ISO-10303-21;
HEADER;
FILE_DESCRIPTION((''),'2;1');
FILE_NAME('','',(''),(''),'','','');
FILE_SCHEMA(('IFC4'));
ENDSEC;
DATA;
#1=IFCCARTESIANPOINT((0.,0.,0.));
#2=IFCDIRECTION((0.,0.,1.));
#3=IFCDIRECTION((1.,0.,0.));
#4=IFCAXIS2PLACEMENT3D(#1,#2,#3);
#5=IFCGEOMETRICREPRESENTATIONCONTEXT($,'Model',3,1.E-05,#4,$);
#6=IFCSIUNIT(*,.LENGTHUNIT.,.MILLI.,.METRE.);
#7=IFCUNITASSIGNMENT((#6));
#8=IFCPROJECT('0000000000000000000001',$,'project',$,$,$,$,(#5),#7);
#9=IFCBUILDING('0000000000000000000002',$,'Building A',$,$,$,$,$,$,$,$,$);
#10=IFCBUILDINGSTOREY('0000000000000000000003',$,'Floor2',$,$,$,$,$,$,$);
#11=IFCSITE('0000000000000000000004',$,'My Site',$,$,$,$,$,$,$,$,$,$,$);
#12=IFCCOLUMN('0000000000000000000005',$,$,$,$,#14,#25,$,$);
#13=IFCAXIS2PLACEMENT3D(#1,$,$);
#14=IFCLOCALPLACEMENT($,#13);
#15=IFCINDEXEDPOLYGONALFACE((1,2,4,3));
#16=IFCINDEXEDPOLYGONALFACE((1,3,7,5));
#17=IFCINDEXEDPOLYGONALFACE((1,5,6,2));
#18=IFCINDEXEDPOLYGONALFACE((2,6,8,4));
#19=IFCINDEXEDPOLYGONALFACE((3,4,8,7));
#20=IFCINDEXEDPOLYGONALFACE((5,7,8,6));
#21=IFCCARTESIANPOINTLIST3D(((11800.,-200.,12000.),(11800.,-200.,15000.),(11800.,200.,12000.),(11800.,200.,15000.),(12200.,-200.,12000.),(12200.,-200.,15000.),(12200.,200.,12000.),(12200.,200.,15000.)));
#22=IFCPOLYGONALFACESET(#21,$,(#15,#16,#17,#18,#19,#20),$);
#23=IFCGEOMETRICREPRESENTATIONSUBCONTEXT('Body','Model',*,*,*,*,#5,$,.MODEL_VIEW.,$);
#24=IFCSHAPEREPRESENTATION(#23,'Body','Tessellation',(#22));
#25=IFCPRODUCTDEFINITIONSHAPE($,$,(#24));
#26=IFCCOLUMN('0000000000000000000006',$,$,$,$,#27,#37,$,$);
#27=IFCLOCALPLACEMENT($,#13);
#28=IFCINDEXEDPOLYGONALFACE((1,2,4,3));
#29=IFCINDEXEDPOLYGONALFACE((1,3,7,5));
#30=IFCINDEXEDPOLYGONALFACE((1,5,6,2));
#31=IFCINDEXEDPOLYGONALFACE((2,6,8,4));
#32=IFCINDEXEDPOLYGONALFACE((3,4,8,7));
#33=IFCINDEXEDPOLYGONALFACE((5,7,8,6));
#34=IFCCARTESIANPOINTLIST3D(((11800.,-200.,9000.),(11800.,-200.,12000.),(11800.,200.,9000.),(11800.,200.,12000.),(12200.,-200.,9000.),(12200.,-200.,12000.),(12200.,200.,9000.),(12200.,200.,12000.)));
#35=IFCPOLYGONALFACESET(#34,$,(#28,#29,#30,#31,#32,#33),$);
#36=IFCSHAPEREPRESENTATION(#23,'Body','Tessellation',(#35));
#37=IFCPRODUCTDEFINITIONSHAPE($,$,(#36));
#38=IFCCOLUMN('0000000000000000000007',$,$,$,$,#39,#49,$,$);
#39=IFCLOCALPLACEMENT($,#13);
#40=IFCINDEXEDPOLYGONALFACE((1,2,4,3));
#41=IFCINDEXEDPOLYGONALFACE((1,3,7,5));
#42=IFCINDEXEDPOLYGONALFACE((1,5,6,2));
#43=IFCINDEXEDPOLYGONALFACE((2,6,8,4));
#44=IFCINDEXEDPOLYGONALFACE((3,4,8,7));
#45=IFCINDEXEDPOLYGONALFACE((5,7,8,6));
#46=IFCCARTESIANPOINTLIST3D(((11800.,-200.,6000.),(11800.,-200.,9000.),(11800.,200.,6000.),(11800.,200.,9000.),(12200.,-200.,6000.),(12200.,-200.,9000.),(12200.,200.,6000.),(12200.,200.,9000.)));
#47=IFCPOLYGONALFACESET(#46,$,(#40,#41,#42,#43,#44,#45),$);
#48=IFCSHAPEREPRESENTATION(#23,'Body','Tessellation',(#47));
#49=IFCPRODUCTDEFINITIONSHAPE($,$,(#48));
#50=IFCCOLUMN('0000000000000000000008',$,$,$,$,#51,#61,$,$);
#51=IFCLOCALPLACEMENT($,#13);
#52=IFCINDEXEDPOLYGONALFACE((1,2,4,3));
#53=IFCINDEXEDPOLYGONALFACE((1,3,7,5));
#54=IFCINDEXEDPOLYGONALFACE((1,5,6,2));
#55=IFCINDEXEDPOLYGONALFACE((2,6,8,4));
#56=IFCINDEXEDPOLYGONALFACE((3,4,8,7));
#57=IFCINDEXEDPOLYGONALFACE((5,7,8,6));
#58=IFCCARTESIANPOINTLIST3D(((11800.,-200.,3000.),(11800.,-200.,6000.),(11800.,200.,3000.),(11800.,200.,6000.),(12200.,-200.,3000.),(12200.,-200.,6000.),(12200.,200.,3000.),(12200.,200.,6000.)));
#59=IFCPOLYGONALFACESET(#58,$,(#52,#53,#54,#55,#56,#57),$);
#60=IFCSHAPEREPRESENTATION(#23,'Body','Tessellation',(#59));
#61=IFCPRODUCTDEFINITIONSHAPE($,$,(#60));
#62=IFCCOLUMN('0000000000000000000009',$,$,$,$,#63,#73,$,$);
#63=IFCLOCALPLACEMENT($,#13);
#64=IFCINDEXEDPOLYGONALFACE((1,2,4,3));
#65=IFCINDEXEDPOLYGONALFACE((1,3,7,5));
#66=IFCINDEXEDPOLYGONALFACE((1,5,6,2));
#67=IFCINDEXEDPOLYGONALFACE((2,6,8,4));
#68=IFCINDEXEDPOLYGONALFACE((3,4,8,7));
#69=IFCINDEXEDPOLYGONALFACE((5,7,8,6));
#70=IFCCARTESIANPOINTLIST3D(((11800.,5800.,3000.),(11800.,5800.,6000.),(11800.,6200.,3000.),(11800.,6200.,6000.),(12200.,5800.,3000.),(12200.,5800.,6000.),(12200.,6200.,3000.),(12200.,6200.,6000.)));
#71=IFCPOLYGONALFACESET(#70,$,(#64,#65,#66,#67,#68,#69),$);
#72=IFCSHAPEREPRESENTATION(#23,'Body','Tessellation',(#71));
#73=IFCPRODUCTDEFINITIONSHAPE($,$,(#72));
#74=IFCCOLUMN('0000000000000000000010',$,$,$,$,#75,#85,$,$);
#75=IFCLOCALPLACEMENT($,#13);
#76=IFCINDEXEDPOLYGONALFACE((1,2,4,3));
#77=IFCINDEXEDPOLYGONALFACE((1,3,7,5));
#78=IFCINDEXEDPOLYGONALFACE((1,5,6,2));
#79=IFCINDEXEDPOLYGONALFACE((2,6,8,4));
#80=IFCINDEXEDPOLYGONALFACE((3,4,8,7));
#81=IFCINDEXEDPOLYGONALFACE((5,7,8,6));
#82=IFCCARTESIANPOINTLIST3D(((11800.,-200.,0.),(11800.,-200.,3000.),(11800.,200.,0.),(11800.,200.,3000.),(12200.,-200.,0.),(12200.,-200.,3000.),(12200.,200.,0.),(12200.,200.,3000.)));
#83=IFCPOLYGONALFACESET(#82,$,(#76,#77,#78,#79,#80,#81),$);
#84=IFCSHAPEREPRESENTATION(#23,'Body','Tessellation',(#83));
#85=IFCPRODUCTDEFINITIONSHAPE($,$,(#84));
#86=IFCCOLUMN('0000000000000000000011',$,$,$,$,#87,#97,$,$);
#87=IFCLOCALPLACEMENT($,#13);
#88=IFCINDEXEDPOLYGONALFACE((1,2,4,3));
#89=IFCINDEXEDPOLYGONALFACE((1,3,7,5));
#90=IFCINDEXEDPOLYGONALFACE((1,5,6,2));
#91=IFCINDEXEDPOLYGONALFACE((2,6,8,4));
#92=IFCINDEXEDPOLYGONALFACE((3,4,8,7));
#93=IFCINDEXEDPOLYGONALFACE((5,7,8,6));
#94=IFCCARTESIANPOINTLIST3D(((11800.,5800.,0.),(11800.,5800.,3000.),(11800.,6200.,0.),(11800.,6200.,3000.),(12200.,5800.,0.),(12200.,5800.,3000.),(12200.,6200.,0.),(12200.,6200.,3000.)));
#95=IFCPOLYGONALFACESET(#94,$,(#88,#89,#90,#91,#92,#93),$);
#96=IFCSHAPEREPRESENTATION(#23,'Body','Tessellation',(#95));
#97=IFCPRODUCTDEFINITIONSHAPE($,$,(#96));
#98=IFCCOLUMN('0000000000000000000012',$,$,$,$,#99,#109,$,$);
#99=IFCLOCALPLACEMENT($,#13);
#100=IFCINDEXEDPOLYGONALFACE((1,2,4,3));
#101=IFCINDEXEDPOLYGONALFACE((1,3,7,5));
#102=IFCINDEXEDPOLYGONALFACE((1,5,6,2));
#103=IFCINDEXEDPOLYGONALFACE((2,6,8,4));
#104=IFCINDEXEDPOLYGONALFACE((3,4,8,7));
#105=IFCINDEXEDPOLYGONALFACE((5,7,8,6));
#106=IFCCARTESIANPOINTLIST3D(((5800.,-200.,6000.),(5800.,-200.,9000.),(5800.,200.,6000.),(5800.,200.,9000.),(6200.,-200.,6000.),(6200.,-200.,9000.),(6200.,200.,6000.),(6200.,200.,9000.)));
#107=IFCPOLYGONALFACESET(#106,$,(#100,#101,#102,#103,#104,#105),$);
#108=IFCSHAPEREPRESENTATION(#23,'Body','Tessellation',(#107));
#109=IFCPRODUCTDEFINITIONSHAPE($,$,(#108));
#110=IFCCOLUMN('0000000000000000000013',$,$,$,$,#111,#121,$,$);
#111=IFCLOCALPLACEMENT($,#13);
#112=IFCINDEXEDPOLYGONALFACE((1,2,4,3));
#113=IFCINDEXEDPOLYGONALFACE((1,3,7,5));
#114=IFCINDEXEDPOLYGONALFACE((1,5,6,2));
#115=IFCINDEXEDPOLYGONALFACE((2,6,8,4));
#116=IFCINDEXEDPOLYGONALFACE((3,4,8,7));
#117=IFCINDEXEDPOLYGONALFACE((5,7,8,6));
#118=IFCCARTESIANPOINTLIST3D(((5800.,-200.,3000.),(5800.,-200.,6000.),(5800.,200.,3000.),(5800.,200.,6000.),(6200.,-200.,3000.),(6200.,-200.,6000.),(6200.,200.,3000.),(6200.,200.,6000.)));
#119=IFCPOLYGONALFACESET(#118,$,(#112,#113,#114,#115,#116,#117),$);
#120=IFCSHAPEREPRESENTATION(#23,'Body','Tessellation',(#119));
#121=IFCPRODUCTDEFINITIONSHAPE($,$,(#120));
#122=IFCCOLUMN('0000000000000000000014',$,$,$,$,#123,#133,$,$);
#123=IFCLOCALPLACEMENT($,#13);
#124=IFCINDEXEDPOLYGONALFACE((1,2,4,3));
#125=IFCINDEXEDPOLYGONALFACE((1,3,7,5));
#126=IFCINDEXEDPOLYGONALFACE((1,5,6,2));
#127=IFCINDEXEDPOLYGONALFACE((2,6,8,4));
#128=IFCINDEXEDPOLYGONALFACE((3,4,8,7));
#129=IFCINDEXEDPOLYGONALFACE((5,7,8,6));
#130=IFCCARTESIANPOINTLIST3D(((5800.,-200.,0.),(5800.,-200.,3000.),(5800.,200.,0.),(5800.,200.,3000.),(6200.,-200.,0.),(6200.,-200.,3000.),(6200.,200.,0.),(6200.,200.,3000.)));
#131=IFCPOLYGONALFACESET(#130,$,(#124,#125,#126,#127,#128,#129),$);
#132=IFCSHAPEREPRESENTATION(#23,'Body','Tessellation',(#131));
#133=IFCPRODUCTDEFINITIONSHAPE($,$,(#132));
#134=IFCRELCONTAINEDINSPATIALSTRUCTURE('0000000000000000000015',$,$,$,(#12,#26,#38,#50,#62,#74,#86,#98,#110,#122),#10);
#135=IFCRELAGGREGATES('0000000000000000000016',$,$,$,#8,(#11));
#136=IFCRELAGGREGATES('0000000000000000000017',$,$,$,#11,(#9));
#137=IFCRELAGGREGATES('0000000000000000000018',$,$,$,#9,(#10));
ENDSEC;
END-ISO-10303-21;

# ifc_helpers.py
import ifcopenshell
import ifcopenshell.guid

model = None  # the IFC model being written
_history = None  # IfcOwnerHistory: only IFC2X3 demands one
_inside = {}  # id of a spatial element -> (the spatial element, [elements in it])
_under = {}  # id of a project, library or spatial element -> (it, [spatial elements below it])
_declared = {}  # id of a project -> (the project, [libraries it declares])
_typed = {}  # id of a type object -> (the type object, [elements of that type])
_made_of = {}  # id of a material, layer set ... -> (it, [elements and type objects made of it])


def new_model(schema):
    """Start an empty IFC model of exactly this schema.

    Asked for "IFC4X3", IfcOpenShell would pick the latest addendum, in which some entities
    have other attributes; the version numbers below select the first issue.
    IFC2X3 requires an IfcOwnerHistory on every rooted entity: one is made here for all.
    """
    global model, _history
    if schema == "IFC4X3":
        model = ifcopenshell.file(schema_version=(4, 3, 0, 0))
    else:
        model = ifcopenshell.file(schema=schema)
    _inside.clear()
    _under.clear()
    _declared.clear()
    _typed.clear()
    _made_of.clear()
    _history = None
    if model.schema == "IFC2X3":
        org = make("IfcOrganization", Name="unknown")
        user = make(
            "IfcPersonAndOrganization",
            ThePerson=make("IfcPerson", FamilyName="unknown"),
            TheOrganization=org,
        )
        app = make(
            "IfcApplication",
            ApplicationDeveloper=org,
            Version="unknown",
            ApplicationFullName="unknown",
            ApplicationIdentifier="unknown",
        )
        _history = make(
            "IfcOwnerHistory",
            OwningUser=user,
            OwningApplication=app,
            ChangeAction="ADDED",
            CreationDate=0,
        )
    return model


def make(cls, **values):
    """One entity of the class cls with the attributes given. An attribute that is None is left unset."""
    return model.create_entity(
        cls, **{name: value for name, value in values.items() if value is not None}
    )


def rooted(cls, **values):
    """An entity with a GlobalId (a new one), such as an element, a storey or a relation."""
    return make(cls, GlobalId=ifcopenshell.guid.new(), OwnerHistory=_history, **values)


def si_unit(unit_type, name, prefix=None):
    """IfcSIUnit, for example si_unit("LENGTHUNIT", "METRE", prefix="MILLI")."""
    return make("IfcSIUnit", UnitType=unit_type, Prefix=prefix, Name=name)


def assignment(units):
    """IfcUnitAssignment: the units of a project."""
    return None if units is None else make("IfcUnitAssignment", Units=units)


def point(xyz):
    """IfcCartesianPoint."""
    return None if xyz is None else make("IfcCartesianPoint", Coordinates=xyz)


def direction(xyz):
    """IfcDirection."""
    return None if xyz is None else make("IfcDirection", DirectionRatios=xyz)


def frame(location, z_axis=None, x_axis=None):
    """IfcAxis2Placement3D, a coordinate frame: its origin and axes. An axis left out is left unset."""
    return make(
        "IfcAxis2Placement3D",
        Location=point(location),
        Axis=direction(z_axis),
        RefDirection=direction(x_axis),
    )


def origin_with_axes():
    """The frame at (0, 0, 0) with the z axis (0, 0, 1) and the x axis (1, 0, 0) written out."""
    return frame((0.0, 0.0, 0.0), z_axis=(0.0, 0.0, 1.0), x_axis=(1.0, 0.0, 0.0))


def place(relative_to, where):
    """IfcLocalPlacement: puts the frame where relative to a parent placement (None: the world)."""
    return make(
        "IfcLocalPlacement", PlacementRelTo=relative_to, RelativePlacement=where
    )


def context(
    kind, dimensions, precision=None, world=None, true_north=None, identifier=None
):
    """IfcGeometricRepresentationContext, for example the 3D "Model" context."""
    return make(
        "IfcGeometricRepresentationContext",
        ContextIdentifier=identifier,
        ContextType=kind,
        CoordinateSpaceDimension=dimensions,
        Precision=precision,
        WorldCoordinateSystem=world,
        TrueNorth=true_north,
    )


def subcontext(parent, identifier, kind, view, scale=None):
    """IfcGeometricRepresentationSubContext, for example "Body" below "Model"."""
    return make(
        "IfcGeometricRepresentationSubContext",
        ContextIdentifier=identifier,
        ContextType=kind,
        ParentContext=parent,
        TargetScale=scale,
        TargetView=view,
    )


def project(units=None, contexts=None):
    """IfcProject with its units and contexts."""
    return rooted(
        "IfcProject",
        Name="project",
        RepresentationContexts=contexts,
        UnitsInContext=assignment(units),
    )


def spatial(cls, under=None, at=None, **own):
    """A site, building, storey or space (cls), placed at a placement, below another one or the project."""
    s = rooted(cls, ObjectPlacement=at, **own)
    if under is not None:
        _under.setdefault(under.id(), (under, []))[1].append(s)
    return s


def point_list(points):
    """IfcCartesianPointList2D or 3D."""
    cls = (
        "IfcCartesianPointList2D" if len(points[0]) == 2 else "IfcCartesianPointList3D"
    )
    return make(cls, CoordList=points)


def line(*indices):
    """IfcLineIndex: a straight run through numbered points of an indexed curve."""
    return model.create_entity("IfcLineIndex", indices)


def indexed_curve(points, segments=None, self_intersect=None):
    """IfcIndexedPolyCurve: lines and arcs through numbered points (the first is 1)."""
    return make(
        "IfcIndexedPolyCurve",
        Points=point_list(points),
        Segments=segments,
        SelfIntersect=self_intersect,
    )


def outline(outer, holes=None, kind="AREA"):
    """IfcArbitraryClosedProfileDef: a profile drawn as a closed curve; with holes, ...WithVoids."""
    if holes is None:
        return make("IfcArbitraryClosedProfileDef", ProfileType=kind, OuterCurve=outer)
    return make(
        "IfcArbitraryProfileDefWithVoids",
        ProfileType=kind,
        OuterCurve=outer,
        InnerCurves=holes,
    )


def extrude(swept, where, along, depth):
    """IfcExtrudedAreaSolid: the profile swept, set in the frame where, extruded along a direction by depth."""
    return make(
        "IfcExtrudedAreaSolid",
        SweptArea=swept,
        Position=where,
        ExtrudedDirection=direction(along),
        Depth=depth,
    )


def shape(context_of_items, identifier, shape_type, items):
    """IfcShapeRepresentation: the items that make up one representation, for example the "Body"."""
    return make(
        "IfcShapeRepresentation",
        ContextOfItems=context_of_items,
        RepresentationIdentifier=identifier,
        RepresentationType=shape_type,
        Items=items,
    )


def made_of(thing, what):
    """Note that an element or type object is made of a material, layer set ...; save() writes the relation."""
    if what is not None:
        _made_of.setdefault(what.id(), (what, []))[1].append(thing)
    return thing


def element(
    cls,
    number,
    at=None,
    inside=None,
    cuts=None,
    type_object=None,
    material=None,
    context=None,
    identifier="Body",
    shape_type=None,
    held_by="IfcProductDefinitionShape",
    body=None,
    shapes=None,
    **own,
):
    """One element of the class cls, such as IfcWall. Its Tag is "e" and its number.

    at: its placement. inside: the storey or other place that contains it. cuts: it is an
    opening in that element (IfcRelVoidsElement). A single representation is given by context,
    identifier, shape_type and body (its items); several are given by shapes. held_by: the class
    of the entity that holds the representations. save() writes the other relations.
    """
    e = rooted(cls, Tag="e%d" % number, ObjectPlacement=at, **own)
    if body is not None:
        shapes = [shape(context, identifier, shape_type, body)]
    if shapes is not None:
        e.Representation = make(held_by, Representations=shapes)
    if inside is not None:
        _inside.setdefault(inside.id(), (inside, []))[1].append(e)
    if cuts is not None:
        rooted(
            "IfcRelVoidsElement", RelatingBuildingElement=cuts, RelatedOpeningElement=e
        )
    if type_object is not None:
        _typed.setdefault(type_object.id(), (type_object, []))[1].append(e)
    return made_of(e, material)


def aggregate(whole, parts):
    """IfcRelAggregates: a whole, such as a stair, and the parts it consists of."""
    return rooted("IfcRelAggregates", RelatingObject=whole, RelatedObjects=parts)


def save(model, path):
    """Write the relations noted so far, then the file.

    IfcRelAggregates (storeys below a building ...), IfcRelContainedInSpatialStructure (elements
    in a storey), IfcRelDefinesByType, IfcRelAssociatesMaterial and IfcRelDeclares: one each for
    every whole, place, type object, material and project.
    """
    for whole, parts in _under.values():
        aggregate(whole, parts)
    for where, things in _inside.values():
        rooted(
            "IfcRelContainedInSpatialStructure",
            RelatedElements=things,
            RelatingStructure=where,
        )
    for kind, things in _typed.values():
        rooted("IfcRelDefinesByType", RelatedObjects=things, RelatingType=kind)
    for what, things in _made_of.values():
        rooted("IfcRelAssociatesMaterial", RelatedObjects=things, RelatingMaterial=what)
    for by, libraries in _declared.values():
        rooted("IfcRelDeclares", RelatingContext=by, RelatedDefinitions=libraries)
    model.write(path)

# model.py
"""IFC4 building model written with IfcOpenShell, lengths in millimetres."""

from ifc_helpers import new_model, si_unit, frame, origin_with_axes, place, context, subcontext, project, spatial, line, indexed_curve, outline, extrude, element, save


model = new_model("IFC4")

# Units and contexts
model_context = context("Model", 3, precision=1e-05, world=origin_with_axes())
body_context = subcontext(model_context, "Body", "Model", "MODEL_VIEW")
ifc_project = project(units=[si_unit("LENGTHUNIT", "METRE", prefix="MILLI")], contexts=[model_context])

# Site, building, storey
site = spatial("IfcSite", under=ifc_project, Name="My Site")
building = spatial("IfcBuilding", under=site, Name="Building A")
storey = spatial("IfcBuildingStorey", under=building, Name="Floor2")

# Columns
for number, where, z_axis, x_axis in (
    (1, (12000.0, 0.0, 12000.0), (0.0, 0.0, 1.0), (1.0, 0.0, 0.0)),
    (2, (12000.0, 0.0, 9000.0), (0.0, 0.0, 1.0), (1.0, 0.0, 0.0)),
    (3, (12000.0, 0.0, 6000.0), (0.0, 0.0, 1.0), (1.0, 0.0, 0.0)),
    (4, (12000.0, 0.0, 3000.0), (0.0, 0.0, 1.0), (1.0, 0.0, 0.0)),
    (5, (12000.0, 6000.0, 3000.0), (0.0, 0.0, 1.0), (1.0, 0.0, 0.0)),
    (6, (12000.0, 0.0, 0.0), (0.0, 0.0, 1.0), (1.0, 0.0, 0.0)),
    (7, (12000.0, 6000.0, 0.0), (0.0, 0.0, 1.0), (1.0, 0.0, 0.0)),
    (8, (6000.0, 0.0, 6000.0), (0.0, 0.0, 1.0), (1.0, 0.0, 0.0)),
    (9, (6000.0, 0.0, 3000.0), (0.0, 0.0, 1.0), (1.0, 0.0, 0.0)),
    (10, (6000.0, 0.0, 0.0), (0.0, 0.0, 1.0), (1.0, 0.0, 0.0)),
):
    element("IfcColumn", number, at=place(None, frame(where, z_axis=z_axis, x_axis=x_axis)), inside=storey, context=body_context, shape_type="SweptSolid", body=[
        extrude(outline(indexed_curve([(-200.0, -200.0), (200.0, -200.0), (200.0, 200.0), (-200.0, 200.0)], segments=[line(1, 2, 3, 4, 1)])), origin_with_axes(), (0.0, 0.0, 1.0), 3000.0),
    ])

save(model, "model.ifc")
